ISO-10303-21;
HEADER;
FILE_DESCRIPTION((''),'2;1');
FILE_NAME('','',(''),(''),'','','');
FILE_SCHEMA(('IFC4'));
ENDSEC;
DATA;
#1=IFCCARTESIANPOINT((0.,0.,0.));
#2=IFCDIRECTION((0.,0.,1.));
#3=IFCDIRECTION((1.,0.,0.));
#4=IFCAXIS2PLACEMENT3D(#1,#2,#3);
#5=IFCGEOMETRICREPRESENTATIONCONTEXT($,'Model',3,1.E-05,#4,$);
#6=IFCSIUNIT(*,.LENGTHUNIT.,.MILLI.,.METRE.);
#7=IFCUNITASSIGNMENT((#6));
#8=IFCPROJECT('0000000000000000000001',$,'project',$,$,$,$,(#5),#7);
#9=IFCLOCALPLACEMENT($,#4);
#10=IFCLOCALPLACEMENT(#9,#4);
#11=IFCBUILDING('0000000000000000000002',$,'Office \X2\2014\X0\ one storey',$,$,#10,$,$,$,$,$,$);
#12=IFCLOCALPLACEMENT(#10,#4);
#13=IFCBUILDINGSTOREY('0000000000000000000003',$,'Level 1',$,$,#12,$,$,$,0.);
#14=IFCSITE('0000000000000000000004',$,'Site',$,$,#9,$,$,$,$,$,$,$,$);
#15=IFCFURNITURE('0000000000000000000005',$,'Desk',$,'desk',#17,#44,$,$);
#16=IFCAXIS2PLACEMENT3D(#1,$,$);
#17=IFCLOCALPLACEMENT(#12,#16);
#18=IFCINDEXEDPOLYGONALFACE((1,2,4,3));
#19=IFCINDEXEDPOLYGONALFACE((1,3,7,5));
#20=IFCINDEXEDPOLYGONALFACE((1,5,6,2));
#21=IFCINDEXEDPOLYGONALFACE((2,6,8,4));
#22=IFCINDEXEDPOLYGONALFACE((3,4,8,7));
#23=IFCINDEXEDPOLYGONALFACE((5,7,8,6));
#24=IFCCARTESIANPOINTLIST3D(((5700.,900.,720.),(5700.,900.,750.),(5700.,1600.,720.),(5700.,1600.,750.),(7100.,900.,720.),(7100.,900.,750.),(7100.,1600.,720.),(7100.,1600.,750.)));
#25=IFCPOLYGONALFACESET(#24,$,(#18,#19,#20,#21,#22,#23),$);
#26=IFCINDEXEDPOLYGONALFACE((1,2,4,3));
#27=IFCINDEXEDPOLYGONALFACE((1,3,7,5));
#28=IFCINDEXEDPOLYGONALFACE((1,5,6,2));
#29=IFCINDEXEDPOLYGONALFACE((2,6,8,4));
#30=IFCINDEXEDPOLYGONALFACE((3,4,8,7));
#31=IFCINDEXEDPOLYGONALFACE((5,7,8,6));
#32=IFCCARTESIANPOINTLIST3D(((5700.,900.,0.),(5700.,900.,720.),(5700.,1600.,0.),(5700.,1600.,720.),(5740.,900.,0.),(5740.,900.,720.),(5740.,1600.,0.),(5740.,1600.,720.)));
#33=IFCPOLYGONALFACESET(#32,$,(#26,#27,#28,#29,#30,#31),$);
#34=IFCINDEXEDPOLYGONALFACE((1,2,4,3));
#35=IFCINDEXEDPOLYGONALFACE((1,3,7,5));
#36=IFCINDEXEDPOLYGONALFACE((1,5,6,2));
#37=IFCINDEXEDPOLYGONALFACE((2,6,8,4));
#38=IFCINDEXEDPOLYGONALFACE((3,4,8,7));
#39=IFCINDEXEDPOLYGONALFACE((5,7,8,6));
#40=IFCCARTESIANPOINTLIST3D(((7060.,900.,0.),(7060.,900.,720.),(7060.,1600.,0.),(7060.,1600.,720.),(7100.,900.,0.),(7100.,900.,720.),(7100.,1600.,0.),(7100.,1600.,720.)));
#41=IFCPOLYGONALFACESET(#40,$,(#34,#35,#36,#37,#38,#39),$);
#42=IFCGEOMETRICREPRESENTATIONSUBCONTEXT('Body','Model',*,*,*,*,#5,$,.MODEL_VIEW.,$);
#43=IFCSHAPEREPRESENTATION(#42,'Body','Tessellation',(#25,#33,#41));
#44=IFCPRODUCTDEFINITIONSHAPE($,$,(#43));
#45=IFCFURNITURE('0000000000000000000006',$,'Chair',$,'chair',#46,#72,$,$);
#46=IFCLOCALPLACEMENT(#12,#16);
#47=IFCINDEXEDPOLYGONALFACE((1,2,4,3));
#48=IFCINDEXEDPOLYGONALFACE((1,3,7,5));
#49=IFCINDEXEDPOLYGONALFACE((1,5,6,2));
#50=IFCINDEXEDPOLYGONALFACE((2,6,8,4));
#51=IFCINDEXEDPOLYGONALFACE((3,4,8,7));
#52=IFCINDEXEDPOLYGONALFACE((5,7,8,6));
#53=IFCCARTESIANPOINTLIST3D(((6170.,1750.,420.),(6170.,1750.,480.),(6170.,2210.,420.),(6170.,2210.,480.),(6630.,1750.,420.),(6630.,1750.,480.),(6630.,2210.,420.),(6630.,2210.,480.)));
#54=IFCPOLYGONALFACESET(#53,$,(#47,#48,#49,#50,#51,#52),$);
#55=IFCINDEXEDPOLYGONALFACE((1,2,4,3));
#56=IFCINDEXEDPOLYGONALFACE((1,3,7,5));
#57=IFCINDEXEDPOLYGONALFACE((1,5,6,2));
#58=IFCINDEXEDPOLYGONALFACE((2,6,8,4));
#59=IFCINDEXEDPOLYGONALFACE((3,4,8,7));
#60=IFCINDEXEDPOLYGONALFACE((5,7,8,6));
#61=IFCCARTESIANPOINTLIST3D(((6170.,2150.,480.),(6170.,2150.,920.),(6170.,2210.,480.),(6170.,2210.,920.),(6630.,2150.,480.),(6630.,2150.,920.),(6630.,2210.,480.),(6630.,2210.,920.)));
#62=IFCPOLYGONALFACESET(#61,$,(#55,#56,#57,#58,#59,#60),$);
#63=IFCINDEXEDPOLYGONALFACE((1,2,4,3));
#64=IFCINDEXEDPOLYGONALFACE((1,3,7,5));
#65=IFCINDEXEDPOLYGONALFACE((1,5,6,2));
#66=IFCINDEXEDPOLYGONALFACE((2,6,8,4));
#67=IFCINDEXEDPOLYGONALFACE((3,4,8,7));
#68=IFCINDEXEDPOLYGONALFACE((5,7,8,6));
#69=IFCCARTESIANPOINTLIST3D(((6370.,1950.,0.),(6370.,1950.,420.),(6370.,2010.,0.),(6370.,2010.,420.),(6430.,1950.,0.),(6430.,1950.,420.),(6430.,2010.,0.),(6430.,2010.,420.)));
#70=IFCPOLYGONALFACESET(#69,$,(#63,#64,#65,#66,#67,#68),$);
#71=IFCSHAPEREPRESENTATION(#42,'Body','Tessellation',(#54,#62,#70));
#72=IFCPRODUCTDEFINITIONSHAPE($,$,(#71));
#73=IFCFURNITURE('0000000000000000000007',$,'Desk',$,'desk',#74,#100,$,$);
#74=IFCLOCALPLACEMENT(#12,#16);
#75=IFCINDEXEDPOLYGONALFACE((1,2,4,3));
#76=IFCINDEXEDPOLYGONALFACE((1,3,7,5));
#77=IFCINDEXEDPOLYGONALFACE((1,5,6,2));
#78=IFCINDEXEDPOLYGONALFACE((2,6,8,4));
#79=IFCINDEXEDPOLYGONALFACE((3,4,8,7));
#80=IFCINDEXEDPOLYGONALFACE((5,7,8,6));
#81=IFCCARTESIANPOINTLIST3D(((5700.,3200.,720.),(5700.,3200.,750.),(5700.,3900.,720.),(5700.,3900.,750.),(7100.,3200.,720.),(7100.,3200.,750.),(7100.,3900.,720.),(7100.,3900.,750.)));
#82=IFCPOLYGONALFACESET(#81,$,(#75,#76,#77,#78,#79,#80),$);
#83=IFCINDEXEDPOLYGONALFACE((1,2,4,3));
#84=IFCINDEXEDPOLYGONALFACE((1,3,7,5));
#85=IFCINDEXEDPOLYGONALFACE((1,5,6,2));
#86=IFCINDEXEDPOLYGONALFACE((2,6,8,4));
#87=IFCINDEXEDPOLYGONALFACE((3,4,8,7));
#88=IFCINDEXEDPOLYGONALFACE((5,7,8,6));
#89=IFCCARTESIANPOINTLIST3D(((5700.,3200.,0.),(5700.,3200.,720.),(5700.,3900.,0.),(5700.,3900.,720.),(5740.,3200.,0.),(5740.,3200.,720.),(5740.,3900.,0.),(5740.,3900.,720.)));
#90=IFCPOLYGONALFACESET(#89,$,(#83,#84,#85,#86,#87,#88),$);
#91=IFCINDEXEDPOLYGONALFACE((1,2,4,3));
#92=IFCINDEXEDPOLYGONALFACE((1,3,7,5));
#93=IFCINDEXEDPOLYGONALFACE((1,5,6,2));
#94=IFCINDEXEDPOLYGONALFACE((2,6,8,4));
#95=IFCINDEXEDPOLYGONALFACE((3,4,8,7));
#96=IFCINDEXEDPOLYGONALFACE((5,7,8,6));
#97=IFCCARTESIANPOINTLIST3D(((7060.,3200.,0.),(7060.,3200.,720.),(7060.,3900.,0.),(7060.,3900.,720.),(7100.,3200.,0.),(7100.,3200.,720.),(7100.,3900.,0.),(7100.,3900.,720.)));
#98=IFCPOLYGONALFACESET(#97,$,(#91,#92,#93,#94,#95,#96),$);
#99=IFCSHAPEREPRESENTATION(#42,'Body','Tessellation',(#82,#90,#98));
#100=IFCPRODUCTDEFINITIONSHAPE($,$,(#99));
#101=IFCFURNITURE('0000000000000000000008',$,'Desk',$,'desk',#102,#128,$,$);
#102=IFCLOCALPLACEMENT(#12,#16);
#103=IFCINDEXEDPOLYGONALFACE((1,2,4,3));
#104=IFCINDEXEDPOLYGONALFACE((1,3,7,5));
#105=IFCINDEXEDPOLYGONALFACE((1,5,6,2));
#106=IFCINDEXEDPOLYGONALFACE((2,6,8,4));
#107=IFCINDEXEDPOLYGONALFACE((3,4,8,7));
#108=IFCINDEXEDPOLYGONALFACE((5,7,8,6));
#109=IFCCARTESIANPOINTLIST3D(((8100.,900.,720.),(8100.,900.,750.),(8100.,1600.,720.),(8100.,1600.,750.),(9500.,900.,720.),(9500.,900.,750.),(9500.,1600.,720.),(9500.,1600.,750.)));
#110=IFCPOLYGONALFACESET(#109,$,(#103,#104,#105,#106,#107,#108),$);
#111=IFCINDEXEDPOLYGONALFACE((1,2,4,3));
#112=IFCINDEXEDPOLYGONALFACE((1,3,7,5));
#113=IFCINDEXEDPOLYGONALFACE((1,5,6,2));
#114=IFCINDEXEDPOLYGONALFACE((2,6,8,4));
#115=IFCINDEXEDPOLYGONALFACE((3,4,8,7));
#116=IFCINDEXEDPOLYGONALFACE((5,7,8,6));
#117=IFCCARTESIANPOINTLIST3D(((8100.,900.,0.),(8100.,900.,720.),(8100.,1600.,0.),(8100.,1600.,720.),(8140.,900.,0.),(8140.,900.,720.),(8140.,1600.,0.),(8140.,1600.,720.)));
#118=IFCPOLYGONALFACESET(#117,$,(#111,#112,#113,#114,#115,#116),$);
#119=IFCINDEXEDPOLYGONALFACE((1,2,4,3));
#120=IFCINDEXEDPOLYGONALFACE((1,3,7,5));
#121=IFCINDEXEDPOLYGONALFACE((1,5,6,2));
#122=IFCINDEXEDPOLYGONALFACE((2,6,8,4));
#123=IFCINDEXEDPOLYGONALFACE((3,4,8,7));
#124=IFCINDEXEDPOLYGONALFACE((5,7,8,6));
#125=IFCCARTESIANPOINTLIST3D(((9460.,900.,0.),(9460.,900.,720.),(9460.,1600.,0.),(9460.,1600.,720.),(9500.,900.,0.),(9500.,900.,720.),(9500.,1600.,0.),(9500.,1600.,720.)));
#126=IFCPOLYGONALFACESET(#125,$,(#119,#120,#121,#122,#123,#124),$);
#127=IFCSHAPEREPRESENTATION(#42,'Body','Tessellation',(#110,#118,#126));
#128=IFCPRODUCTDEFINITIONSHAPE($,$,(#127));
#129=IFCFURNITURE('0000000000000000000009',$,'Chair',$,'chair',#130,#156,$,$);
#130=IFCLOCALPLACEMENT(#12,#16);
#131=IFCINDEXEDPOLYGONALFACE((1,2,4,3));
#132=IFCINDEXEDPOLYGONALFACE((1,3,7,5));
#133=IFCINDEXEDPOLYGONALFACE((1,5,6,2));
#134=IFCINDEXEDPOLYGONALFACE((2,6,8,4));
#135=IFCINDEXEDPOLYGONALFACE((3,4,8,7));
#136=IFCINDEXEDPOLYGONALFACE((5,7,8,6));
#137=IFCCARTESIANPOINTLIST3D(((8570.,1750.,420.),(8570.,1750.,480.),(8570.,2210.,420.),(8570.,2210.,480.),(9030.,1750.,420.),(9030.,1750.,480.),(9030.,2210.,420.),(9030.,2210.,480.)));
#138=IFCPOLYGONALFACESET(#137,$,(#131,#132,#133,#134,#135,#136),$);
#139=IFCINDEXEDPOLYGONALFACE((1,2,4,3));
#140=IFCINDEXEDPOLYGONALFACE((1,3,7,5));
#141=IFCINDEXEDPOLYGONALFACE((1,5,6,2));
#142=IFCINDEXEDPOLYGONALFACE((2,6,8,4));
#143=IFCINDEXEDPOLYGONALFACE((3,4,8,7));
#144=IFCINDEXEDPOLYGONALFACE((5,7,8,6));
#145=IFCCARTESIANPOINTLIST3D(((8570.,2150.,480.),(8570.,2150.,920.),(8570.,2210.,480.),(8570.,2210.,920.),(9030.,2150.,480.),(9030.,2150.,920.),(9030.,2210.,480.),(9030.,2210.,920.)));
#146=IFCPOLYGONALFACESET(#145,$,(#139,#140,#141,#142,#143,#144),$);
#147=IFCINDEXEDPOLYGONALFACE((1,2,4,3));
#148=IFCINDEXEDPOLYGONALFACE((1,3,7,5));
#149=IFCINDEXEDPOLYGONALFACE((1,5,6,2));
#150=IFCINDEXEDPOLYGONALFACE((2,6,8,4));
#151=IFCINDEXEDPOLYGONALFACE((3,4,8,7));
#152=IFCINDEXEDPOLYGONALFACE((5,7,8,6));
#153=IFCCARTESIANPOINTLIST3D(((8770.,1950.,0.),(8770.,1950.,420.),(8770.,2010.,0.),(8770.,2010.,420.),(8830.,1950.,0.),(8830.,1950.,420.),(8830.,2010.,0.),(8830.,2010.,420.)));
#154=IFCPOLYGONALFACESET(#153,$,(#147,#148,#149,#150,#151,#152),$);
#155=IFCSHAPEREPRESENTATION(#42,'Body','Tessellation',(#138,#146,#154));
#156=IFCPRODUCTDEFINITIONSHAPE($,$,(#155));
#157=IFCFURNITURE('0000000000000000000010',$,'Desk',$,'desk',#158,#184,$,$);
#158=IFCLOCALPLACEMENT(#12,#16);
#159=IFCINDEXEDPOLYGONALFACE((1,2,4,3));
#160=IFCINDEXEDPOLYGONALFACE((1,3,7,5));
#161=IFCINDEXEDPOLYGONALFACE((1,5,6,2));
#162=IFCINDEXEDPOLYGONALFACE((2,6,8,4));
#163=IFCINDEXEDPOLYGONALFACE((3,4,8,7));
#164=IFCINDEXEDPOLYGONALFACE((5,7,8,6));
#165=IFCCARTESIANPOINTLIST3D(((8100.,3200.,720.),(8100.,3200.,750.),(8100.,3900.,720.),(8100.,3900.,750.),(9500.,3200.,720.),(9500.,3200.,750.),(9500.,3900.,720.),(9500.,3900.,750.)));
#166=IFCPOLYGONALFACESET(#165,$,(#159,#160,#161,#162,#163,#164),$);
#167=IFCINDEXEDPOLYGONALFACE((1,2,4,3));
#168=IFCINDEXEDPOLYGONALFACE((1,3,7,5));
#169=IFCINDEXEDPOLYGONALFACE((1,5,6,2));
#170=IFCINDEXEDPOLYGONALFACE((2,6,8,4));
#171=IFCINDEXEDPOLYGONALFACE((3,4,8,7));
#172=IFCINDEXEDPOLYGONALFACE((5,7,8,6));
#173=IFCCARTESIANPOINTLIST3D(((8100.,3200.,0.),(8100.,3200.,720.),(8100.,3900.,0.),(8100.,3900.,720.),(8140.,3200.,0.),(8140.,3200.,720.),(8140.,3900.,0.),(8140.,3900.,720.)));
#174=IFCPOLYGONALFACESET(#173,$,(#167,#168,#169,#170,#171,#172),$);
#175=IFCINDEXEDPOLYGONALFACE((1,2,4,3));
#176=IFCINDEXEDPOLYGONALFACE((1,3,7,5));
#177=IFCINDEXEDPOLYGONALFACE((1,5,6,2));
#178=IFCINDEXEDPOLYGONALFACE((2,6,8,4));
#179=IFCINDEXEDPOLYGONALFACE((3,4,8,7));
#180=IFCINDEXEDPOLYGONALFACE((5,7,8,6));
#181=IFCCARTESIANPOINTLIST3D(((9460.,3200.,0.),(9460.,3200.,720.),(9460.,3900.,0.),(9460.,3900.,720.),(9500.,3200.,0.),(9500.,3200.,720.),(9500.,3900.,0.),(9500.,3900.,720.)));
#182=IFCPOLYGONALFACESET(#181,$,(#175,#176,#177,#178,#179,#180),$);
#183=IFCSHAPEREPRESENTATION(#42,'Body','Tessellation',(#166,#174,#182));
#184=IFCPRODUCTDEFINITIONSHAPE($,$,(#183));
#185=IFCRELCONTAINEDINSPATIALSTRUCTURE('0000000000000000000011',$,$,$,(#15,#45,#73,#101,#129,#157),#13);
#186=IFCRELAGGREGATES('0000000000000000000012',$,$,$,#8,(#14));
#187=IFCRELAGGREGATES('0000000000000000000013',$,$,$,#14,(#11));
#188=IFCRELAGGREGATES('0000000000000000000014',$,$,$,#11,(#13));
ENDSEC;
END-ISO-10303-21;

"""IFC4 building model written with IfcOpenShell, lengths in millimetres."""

from ifc_helpers import new_model, si_unit, frame, frame_2d, origin, origin_with_axes, place, context, subcontext, project, spatial, rectangle, extrude, element, save


model = new_model("IFC4")

# Units and contexts
model_context = context("Model", 3, precision=1e-05, world=origin_with_axes())
body_context = subcontext(model_context, "Body", "Model", "MODEL_VIEW")
ifc_project = project(units=[si_unit("LENGTHUNIT", "METRE", prefix="MILLI")], contexts=[model_context])

# Site, building, storey
site_placement = place(None, origin_with_axes())
site = spatial("IfcSite", under=ifc_project, at=site_placement, Name="Site")
building_placement = place(site_placement, origin_with_axes())
building = spatial("IfcBuilding", under=site, at=building_placement, Name="Office — one storey")
storey_placement = place(building_placement, origin_with_axes())
storey = spatial("IfcBuildingStorey", under=building, at=storey_placement, Name="Level 1", Elevation=0.0)

# Furniture
furniture_1_placement = place(storey_placement, frame((5700.0, 900.0, 0.0), z_axis=(0.0, 0.0, 1.0), x_axis=(1.0, 0.0, 0.0)))
element("IfcFurniture", 1, at=furniture_1_placement, inside=storey, Name="Desk", ObjectType="desk", context=body_context, shape_type="SweptSolid", body=[
    extrude(rectangle(XDim=1400.0, YDim=700.0, at=frame_2d((700.0, 350.0))), frame((0.0, 0.0, 720.0)), (0.0, 0.0, 1.0), 30.0),
    extrude(rectangle(XDim=40.0, YDim=700.0, at=frame_2d((20.0, 350.0))), origin(), (0.0, 0.0, 1.0), 720.0),
    extrude(rectangle(XDim=40.0, YDim=700.0, at=frame_2d((1380.0, 350.0))), origin(), (0.0, 0.0, 1.0), 720.0),
])
furniture_2_placement = place(storey_placement, frame((6170.0, 1750.0, 0.0), z_axis=(0.0, 0.0, 1.0), x_axis=(1.0, 0.0, 0.0)))
element("IfcFurniture", 2, at=furniture_2_placement, inside=storey, Name="Chair", ObjectType="chair", context=body_context, shape_type="SweptSolid", body=[
    extrude(rectangle(XDim=460.0, YDim=460.0, at=frame_2d((230.0, 230.0))), frame((0.0, 0.0, 420.0)), (0.0, 0.0, 1.0), 60.0),
    extrude(rectangle(XDim=460.0, YDim=60.0, at=frame_2d((230.0, 430.0))), frame((0.0, 0.0, 480.0)), (0.0, 0.0, 1.0), 440.0),
    extrude(rectangle(XDim=60.0, YDim=60.0, at=frame_2d((230.0, 230.0))), origin(), (0.0, 0.0, 1.0), 420.0),
])
for number, where, z_axis, x_axis, name in (
    (3, (5700.0, 3200.0, 0.0), (0.0, 0.0, 1.0), (1.0, 0.0, 0.0), "Desk"),
    (4, (8100.0, 900.0, 0.0), (0.0, 0.0, 1.0), (1.0, 0.0, 0.0), "Desk"),
):
    element("IfcFurniture", number, at=place(storey_placement, frame(where, z_axis=z_axis, x_axis=x_axis)), inside=storey, Name=name, ObjectType="desk", context=body_context, shape_type="SweptSolid", body=[
        extrude(rectangle(XDim=1400.0, YDim=700.0, at=frame_2d((700.0, 350.0))), frame((0.0, 0.0, 720.0)), (0.0, 0.0, 1.0), 30.0),
        extrude(rectangle(XDim=40.0, YDim=700.0, at=frame_2d((20.0, 350.0))), origin(), (0.0, 0.0, 1.0), 720.0),
        extrude(rectangle(XDim=40.0, YDim=700.0, at=frame_2d((1380.0, 350.0))), origin(), (0.0, 0.0, 1.0), 720.0),
    ])
furniture_3_placement = place(storey_placement, frame((8570.0, 1750.0, 0.0), z_axis=(0.0, 0.0, 1.0), x_axis=(1.0, 0.0, 0.0)))
element("IfcFurniture", 5, at=furniture_3_placement, inside=storey, Name="Chair", ObjectType="chair", context=body_context, shape_type="SweptSolid", body=[
    extrude(rectangle(XDim=460.0, YDim=460.0, at=frame_2d((230.0, 230.0))), frame((0.0, 0.0, 420.0)), (0.0, 0.0, 1.0), 60.0),
    extrude(rectangle(XDim=460.0, YDim=60.0, at=frame_2d((230.0, 430.0))), frame((0.0, 0.0, 480.0)), (0.0, 0.0, 1.0), 440.0),
    extrude(rectangle(XDim=60.0, YDim=60.0, at=frame_2d((230.0, 230.0))), origin(), (0.0, 0.0, 1.0), 420.0),
])
furniture_4_placement = place(storey_placement, frame((8100.0, 3200.0, 0.0), z_axis=(0.0, 0.0, 1.0), x_axis=(1.0, 0.0, 0.0)))
element("IfcFurniture", 6, at=furniture_4_placement, inside=storey, Name="Desk", ObjectType="desk", context=body_context, shape_type="SweptSolid", body=[
    extrude(rectangle(XDim=1400.0, YDim=700.0, at=frame_2d((700.0, 350.0))), frame((0.0, 0.0, 720.0)), (0.0, 0.0, 1.0), 30.0),
    extrude(rectangle(XDim=40.0, YDim=700.0, at=frame_2d((20.0, 350.0))), origin(), (0.0, 0.0, 1.0), 720.0),
    extrude(rectangle(XDim=40.0, YDim=700.0, at=frame_2d((1380.0, 350.0))), origin(), (0.0, 0.0, 1.0), 720.0),
])

save(model, "model.ifc")
